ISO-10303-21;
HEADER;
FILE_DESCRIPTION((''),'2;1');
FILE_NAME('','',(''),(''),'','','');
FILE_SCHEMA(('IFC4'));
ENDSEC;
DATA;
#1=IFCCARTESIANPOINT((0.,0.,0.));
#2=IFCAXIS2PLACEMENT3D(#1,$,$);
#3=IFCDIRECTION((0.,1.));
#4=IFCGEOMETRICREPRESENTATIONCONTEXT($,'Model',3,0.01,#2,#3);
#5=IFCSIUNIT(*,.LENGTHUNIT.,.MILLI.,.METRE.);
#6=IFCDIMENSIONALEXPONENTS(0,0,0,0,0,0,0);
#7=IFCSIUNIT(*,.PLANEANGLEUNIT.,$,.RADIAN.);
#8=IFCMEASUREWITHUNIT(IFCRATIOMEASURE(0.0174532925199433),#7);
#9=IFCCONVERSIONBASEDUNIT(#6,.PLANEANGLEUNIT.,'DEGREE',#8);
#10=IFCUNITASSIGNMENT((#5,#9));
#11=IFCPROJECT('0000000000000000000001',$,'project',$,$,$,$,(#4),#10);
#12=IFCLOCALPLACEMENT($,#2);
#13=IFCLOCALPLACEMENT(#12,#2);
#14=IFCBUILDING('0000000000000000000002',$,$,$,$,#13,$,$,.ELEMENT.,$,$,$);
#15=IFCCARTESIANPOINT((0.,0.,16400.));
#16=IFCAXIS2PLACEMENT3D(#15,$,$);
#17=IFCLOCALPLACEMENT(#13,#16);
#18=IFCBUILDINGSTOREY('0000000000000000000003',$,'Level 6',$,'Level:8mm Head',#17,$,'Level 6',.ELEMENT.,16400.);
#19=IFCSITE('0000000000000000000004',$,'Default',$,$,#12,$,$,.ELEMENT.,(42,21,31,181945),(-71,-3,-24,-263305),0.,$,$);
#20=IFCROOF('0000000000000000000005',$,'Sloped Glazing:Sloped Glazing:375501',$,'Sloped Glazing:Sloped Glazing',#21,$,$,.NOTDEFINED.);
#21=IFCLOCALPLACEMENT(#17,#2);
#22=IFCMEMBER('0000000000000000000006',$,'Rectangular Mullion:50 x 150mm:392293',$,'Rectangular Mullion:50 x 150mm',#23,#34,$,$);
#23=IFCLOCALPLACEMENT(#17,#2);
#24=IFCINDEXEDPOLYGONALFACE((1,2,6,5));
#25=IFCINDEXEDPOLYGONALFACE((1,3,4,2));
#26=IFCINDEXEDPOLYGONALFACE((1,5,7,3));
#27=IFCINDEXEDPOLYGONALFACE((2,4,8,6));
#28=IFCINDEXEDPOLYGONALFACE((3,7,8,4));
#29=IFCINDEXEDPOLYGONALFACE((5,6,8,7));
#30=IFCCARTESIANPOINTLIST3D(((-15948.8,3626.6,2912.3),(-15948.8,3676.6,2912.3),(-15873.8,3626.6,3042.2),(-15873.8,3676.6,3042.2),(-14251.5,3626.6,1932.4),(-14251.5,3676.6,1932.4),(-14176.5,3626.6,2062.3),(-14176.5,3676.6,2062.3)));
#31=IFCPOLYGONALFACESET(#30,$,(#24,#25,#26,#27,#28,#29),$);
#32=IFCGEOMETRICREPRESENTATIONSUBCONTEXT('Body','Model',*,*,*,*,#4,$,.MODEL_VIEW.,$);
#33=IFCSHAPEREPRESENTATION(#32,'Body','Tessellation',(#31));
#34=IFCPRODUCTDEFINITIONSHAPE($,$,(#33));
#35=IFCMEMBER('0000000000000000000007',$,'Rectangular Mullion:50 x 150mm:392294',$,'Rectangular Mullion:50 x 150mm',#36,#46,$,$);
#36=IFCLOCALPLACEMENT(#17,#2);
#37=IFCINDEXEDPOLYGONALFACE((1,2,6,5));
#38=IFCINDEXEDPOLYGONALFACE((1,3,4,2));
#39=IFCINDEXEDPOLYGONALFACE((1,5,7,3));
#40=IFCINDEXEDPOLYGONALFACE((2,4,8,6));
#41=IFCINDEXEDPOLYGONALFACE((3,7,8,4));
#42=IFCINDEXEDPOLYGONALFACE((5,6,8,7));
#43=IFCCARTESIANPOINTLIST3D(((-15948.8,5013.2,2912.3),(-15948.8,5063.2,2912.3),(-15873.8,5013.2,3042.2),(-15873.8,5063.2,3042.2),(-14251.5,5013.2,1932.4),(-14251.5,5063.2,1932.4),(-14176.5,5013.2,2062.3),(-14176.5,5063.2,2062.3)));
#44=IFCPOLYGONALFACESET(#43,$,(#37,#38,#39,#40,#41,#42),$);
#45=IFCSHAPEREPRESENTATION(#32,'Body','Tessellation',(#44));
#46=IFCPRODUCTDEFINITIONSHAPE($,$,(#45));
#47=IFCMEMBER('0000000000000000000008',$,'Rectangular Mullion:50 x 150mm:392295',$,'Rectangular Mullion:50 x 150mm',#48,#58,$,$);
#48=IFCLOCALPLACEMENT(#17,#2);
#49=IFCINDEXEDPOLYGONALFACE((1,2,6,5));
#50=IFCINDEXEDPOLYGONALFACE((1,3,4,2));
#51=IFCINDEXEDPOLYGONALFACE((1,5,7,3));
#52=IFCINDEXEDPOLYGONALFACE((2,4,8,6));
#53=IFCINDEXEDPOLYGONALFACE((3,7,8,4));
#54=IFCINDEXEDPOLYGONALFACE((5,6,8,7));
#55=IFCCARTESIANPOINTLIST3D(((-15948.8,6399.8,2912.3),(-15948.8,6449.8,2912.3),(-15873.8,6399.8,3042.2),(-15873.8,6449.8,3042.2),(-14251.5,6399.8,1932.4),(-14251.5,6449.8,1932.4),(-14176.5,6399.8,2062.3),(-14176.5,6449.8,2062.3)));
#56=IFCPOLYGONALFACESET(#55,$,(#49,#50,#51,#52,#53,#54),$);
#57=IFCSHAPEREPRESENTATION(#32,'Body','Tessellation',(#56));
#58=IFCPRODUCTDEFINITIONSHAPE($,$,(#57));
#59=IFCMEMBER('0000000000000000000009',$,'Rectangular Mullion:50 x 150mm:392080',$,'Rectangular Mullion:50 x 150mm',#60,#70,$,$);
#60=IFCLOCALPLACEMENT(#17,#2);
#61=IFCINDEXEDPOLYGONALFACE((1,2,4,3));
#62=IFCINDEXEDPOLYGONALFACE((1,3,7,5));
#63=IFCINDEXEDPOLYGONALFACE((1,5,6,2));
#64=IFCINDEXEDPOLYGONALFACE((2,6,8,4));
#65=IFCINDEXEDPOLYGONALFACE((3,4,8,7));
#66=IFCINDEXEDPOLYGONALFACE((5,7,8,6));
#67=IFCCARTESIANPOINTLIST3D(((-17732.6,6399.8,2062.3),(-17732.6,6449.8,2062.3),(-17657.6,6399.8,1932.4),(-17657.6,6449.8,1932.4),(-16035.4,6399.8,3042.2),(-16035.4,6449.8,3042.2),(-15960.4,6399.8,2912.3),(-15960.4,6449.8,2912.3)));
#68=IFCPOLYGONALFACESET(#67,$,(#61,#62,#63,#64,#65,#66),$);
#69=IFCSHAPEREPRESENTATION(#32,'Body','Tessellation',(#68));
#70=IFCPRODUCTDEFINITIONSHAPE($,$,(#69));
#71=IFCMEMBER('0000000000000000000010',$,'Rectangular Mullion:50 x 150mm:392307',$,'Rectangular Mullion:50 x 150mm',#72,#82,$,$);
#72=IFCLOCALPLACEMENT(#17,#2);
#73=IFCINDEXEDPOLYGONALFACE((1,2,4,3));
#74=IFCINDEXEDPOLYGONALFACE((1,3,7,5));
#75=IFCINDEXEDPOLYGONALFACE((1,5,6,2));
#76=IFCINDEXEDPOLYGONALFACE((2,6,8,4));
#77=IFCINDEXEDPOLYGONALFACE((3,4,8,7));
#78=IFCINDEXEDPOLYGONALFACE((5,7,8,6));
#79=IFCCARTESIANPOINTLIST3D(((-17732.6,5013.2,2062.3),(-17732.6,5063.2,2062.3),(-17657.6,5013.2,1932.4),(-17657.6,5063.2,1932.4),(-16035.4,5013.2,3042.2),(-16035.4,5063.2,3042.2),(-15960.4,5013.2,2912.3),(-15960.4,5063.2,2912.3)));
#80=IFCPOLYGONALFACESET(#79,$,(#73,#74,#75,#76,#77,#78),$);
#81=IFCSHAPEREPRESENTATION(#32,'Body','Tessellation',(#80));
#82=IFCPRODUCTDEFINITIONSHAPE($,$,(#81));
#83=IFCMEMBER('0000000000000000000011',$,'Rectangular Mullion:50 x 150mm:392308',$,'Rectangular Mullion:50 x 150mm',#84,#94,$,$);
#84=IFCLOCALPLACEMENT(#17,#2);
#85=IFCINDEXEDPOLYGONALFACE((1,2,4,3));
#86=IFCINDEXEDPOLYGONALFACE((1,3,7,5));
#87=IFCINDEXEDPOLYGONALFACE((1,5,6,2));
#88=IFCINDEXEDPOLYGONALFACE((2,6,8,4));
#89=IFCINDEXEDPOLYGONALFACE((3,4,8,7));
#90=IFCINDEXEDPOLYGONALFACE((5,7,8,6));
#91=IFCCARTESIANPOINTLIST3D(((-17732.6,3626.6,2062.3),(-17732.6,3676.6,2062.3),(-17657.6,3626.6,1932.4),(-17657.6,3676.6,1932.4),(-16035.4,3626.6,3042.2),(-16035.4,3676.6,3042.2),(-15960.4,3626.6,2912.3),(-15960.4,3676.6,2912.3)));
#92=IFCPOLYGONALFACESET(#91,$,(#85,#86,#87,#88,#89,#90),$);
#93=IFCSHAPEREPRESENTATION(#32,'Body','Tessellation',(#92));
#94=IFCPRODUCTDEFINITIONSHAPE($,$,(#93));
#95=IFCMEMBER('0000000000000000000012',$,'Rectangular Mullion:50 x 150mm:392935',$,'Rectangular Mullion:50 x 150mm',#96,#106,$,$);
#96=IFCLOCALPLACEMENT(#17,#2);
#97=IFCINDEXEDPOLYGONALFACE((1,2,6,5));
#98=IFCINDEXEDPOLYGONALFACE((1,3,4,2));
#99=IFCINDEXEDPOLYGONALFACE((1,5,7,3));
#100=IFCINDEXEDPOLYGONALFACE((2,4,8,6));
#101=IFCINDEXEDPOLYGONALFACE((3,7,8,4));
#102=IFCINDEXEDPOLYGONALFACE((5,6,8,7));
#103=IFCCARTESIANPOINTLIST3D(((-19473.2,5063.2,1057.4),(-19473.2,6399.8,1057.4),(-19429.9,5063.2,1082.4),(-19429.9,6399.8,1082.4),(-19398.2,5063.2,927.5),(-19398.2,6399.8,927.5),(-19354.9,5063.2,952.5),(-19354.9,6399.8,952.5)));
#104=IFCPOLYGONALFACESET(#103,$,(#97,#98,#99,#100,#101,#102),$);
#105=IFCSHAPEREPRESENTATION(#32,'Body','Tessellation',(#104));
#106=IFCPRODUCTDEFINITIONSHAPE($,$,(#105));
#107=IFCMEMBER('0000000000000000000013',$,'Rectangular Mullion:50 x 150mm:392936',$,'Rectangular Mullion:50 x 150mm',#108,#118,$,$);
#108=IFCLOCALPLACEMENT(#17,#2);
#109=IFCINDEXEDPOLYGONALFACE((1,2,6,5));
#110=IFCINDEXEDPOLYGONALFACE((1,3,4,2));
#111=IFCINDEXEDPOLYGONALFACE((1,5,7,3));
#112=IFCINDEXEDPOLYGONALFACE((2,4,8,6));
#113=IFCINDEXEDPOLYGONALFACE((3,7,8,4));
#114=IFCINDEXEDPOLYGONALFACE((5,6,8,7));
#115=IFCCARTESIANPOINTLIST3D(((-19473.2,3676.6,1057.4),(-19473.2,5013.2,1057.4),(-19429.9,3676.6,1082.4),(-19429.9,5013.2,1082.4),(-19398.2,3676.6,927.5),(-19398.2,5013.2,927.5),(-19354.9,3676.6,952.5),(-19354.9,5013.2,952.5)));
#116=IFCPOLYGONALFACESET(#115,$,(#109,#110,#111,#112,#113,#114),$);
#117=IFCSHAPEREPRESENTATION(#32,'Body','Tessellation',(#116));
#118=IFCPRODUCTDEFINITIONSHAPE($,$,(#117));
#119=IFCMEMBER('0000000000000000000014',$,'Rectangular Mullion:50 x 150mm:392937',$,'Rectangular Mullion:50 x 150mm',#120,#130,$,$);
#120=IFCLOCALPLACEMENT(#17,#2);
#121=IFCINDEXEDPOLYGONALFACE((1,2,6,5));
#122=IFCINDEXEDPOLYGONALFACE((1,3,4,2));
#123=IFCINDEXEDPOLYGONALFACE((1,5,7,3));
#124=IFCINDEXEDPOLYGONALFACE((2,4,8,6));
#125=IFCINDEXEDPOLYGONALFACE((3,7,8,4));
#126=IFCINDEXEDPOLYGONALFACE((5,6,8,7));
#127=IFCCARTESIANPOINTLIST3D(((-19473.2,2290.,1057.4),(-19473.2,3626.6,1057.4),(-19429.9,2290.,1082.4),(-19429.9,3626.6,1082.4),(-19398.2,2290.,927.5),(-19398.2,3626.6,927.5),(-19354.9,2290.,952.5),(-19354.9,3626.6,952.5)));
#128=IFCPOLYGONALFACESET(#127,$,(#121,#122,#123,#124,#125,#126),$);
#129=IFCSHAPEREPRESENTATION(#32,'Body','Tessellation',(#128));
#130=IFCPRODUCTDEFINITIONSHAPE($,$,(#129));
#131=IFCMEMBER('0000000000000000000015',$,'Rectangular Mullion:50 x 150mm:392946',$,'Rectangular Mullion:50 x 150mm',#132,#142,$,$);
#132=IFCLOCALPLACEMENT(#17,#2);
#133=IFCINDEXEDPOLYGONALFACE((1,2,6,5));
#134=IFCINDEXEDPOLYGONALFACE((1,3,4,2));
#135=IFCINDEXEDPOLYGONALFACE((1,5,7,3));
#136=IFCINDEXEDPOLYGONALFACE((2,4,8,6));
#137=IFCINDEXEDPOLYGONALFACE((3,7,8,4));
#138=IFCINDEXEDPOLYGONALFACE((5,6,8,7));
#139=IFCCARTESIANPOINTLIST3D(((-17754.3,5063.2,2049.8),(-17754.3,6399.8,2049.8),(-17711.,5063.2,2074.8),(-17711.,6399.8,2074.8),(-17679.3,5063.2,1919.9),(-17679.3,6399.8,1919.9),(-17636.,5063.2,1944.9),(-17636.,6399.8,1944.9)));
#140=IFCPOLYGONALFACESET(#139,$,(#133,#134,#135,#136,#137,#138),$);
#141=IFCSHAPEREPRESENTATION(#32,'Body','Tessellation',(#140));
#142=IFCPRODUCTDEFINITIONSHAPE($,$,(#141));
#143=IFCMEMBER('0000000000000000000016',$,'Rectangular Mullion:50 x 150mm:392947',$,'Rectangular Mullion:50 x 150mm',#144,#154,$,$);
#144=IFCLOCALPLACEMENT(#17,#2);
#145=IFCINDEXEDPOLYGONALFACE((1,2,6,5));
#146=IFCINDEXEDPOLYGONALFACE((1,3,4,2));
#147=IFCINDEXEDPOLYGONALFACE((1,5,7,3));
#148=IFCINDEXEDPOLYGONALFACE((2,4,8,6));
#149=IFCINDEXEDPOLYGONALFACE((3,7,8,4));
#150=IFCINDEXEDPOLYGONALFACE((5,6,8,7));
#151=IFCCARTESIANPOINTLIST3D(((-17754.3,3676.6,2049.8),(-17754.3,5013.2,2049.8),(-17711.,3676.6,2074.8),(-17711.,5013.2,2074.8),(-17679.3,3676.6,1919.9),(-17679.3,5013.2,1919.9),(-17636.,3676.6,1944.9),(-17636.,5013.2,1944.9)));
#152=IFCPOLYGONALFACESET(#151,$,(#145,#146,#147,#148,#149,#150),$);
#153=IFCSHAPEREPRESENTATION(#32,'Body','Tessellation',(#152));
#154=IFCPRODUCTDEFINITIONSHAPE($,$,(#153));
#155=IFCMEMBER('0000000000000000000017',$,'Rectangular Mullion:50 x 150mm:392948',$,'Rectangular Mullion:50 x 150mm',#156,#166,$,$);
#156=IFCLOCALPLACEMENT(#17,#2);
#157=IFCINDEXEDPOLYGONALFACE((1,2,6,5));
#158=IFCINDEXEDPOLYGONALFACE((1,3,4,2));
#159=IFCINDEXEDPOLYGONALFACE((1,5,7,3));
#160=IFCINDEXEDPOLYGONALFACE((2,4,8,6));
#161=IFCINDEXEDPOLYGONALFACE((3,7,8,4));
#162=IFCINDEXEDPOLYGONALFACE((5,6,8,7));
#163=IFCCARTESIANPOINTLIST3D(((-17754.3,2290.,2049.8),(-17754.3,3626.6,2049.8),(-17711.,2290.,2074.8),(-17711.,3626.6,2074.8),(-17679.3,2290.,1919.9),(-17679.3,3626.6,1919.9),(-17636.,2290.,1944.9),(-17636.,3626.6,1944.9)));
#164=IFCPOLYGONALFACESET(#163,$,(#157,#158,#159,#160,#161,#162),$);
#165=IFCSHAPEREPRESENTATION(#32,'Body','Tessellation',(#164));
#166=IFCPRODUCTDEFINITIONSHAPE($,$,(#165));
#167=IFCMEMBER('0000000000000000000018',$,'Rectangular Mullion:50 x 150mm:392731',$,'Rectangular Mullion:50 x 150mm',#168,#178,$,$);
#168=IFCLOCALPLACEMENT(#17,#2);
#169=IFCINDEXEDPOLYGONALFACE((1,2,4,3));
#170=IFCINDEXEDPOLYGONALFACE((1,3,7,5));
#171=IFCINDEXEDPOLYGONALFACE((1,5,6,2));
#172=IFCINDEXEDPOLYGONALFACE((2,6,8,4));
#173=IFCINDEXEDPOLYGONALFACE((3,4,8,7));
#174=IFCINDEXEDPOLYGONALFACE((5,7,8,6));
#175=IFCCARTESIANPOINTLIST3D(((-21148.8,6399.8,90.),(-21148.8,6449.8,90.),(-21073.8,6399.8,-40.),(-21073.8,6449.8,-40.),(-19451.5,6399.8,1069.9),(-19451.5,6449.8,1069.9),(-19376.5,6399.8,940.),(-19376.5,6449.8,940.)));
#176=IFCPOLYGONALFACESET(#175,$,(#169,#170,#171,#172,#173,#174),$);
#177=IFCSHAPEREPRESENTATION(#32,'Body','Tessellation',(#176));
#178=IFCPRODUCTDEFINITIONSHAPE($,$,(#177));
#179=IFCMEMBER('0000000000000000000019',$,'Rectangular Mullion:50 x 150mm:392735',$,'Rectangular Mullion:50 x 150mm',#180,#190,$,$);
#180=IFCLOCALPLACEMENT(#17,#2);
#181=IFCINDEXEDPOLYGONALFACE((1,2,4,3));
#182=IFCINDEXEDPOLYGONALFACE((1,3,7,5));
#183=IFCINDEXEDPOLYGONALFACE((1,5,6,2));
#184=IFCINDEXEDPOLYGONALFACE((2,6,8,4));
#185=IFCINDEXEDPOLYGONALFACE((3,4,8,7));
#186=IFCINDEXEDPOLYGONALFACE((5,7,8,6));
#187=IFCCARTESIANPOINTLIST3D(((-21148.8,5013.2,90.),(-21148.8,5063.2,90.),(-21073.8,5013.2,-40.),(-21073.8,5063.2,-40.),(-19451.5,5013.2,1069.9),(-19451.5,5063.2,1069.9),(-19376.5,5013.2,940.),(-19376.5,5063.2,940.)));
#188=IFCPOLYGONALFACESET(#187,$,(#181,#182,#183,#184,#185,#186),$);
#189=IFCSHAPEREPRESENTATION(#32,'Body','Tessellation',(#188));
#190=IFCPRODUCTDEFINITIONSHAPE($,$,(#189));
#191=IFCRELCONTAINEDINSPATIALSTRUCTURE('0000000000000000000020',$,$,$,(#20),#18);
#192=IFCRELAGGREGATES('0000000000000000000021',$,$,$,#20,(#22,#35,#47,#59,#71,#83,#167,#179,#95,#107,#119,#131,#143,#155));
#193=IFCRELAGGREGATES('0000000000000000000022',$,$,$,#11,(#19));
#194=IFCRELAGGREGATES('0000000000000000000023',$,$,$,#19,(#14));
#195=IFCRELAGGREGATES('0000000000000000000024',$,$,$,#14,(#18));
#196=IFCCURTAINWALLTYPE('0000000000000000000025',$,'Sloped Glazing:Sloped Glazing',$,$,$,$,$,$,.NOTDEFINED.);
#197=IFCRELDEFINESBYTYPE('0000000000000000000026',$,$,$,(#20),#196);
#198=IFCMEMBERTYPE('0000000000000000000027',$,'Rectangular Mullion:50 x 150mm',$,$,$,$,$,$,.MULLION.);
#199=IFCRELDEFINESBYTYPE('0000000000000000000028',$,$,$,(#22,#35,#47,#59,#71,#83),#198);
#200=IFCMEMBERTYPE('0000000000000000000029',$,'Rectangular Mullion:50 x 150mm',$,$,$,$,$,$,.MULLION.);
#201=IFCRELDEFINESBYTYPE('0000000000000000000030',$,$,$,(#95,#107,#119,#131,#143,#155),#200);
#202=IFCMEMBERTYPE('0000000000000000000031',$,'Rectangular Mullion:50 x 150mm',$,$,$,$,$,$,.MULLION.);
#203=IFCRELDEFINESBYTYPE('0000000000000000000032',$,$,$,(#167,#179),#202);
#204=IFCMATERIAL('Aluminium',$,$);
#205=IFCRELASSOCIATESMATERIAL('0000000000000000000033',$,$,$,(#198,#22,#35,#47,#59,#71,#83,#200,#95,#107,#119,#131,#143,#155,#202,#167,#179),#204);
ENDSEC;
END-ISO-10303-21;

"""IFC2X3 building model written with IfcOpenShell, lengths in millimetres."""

from ifc_helpers import new_model, entity, si_unit, converted_unit, direction, frame, origin, origin_2d_with_axis, place, context, subcontext, project, spatial, rectangle, extrude, source, transform, mapped, material, type_object, type_shapes, element, aggregate, save


model = new_model("IFC2X3")

# Units and contexts
model_context = context("Model", 3, precision=0.01, world=origin(), true_north=direction((0.0, 1.0)))
body_context = subcontext(model_context, "Body", "Model", "MODEL_VIEW")
ifc_project = project(units=[si_unit("LENGTHUNIT", "METRE", prefix="MILLI"), converted_unit("PLANEANGLEUNIT", "DEGREE", entity("IfcRatioMeasure", 0.0174532925199433), si_unit("PLANEANGLEUNIT", "RADIAN"), dimensions=[0, 0, 0, 0, 0, 0, 0])], contexts=[model_context])

# Site, building, storey
site_placement = place(None, frame((0.0, 0.0, 0.0)))
site = spatial("IfcSite", under=ifc_project, at=site_placement, Name="Default", CompositionType="ELEMENT", RefLatitude=(42, 21, 31, 181945), RefLongitude=(-71, -3, -24, -263305), RefElevation=0.0)
building_placement = place(site_placement, origin())
building = spatial("IfcBuilding", under=site, at=building_placement, CompositionType="ELEMENT")
storey_placement = place(building_placement, frame((0.0, 0.0, 16400.0)))
storey = spatial("IfcBuildingStorey", under=building, at=storey_placement, Name="Level 6", ObjectType="Level:8mm Head", LongName="Level 6", CompositionType="ELEMENT", Elevation=16400.0)

# Roof, members
curtain_wall_type = type_object("IfcCurtainWallType", Name="Sloped Glazing:Sloped Glazing", PredefinedType="NOTDEFINED")
roof_placement = place(storey_placement, frame((0.0, 0.0, -16400.0)))
roof = element("IfcRoof", 1, at=roof_placement, inside=storey, type_object=curtain_wall_type, Name="Sloped Glazing:Sloped Glazing:375501", ObjectType="Sloped Glazing:Sloped Glazing", ShapeType="NOTDEFINED")
ifc_material_1 = material(Name="Aluminium")
member_type_1 = type_object("IfcMemberType", Name="Rectangular Mullion:50 x 150mm", PredefinedType="MULLION", material=ifc_material_1)
shared_shape_1 = source(origin(), body_context, "Body", "SweptSolid", [
    extrude(rectangle(XDim=150.0, YDim=50.0, at=origin_2d_with_axis()), frame((0.0, 0.0, -1959.8), z_axis=(0.0, 0.0, 1.0), x_axis=(0.0, -1.0, 0.0)), (0.0, 0.0, 1.0), 1959.8),
])
type_shapes(member_type_1, [shared_shape_1])
member_1_placement = place(storey_placement, frame((-15911.3, 3651.6, 2977.2), z_axis=(-0.866025, 0.0, 0.5), x_axis=(0.0, 1.0, 0.0)))
member_1 = element("IfcMember", 2, at=member_1_placement, type_object=member_type_1, material=ifc_material_1, Name="Rectangular Mullion:50 x 150mm:392293", ObjectType="Rectangular Mullion:50 x 150mm", context=body_context, shape_type="MappedRepresentation", body=[
    mapped(shared_shape_1, transform((0.0, 0.0, 0.0), scale=1.0)),
])
member_2_placement = place(storey_placement, frame((-15911.3, 5038.2, 2977.2), z_axis=(-0.866025, 0.0, 0.5), x_axis=(0.0, 1.0, 0.0)))
member_2 = element("IfcMember", 3, at=member_2_placement, type_object=member_type_1, material=ifc_material_1, Name="Rectangular Mullion:50 x 150mm:392294", ObjectType="Rectangular Mullion:50 x 150mm", context=body_context, shape_type="MappedRepresentation", body=[
    mapped(shared_shape_1, transform((0.0, 0.0, 0.0), scale=1.0)),
])
member_3_placement = place(storey_placement, frame((-15911.3, 6424.8, 2977.2), z_axis=(-0.866025, 0.0, 0.5), x_axis=(0.0, 1.0, 0.0)))
member_3 = element("IfcMember", 4, at=member_3_placement, type_object=member_type_1, material=ifc_material_1, Name="Rectangular Mullion:50 x 150mm:392295", ObjectType="Rectangular Mullion:50 x 150mm", context=body_context, shape_type="MappedRepresentation", body=[
    mapped(shared_shape_1, transform((0.0, 0.0, 0.0), scale=1.0)),
])
member_4_placement = place(storey_placement, frame((-15997.9, 6424.8, 2977.2), z_axis=(0.866025, 0.0, 0.5), x_axis=(0.0, -1.0, 0.0)))
member_4 = element("IfcMember", 5, at=member_4_placement, type_object=member_type_1, material=ifc_material_1, Name="Rectangular Mullion:50 x 150mm:392080", ObjectType="Rectangular Mullion:50 x 150mm", context=body_context, shape_type="MappedRepresentation", body=[
    mapped(shared_shape_1, transform((0.0, 0.0, 0.0), scale=1.0)),
])
member_5_placement = place(storey_placement, frame((-15997.9, 5038.2, 2977.2), z_axis=(0.866025, 0.0, 0.5), x_axis=(0.0, -1.0, 0.0)))
member_5 = element("IfcMember", 6, at=member_5_placement, type_object=member_type_1, material=ifc_material_1, Name="Rectangular Mullion:50 x 150mm:392307", ObjectType="Rectangular Mullion:50 x 150mm", context=body_context, shape_type="MappedRepresentation", body=[
    mapped(shared_shape_1, transform((0.0, 0.0, 0.0), scale=1.0)),
])
member_6_placement = place(storey_placement, frame((-15997.9, 3651.6, 2977.2), z_axis=(0.866025, 0.0, 0.5), x_axis=(0.0, -1.0, 0.0)))
member_6 = element("IfcMember", 7, at=member_6_placement, type_object=member_type_1, material=ifc_material_1, Name="Rectangular Mullion:50 x 150mm:392308", ObjectType="Rectangular Mullion:50 x 150mm", context=body_context, shape_type="MappedRepresentation", body=[
    mapped(shared_shape_1, transform((0.0, 0.0, 0.0), scale=1.0)),
])
member_type_2 = type_object("IfcMemberType", Name="Rectangular Mullion:50 x 150mm", PredefinedType="MULLION", material=ifc_material_1)
shared_shape_2 = source(origin(), body_context, "Body", "SweptSolid", [
    extrude(rectangle(XDim=150.0, YDim=50.0, at=origin_2d_with_axis()), frame((0.0, 0.0, -1336.6), z_axis=(0.0, 0.0, 1.0), x_axis=(0.0, -1.0, 0.0)), (0.0, 0.0, 1.0), 1336.6),
])
type_shapes(member_type_2, [shared_shape_2])
member_7_placement = place(storey_placement, frame((-19414.0, 6399.8, 1004.9), z_axis=(0.0, 1.0, 0.0), x_axis=(0.866025, 0.0, 0.5)))
member_7 = element("IfcMember", 8, at=member_7_placement, type_object=member_type_2, material=ifc_material_1, Name="Rectangular Mullion:50 x 150mm:392935", ObjectType="Rectangular Mullion:50 x 150mm", context=body_context, shape_type="MappedRepresentation", body=[
    mapped(shared_shape_2, transform((0.0, 0.0, 0.0), scale=1.0)),
])
member_8_placement = place(storey_placement, frame((-19414.0, 5013.2, 1004.9), z_axis=(0.0, 1.0, 0.0), x_axis=(0.866025, 0.0, 0.5)))
member_8 = element("IfcMember", 9, at=member_8_placement, type_object=member_type_2, material=ifc_material_1, Name="Rectangular Mullion:50 x 150mm:392936", ObjectType="Rectangular Mullion:50 x 150mm", context=body_context, shape_type="MappedRepresentation", body=[
    mapped(shared_shape_2, transform((0.0, 0.0, 0.0), scale=1.0)),
])
member_9_placement = place(storey_placement, frame((-19414.0, 3626.6, 1004.9), z_axis=(0.0, 1.0, 0.0), x_axis=(0.866025, 0.0, 0.5)))
member_9 = element("IfcMember", 10, at=member_9_placement, type_object=member_type_2, material=ifc_material_1, Name="Rectangular Mullion:50 x 150mm:392937", ObjectType="Rectangular Mullion:50 x 150mm", context=body_context, shape_type="MappedRepresentation", body=[
    mapped(shared_shape_2, transform((0.0, 0.0, 0.0), scale=1.0)),
])
member_10_placement = place(storey_placement, frame((-17695.1, 6399.8, 1997.3), z_axis=(0.0, 1.0, 0.0), x_axis=(0.866025, 0.0, 0.5)))
member_10 = element("IfcMember", 11, at=member_10_placement, type_object=member_type_2, material=ifc_material_1, Name="Rectangular Mullion:50 x 150mm:392946", ObjectType="Rectangular Mullion:50 x 150mm", context=body_context, shape_type="MappedRepresentation", body=[
    mapped(shared_shape_2, transform((0.0, 0.0, 0.0), scale=1.0)),
])
member_11_placement = place(storey_placement, frame((-17695.1, 5013.2, 1997.3), z_axis=(0.0, 1.0, 0.0), x_axis=(0.866025, 0.0, 0.5)))
member_11 = element("IfcMember", 12, at=member_11_placement, type_object=member_type_2, material=ifc_material_1, Name="Rectangular Mullion:50 x 150mm:392947", ObjectType="Rectangular Mullion:50 x 150mm", context=body_context, shape_type="MappedRepresentation", body=[
    mapped(shared_shape_2, transform((0.0, 0.0, 0.0), scale=1.0)),
])
member_12_placement = place(storey_placement, frame((-17695.1, 3626.6, 1997.3), z_axis=(0.0, 1.0, 0.0), x_axis=(0.866025, 0.0, 0.5)))
member_12 = element("IfcMember", 13, at=member_12_placement, type_object=member_type_2, material=ifc_material_1, Name="Rectangular Mullion:50 x 150mm:392948", ObjectType="Rectangular Mullion:50 x 150mm", context=body_context, shape_type="MappedRepresentation", body=[
    mapped(shared_shape_2, transform((0.0, 0.0, 0.0), scale=1.0)),
])
member_type_3 = type_object("IfcMemberType", Name="Rectangular Mullion:50 x 150mm", PredefinedType="MULLION", material=ifc_material_1)
shared_shape_3 = source(origin(), body_context, "Body", "SweptSolid", [
    extrude(rectangle(XDim=150.0, YDim=50.0, at=origin_2d_with_axis()), frame((0.0, 0.0, -1959.8), z_axis=(0.0, 0.0, 1.0), x_axis=(0.0, -1.0, 0.0)), (0.0, 0.0, 1.0), 1959.8),
])
type_shapes(member_type_3, [shared_shape_3])
member_13_placement = place(storey_placement, frame((-19414.0, 6424.8, 1004.9), z_axis=(0.866025, 0.0, 0.5), x_axis=(0.0, -1.0, 0.0)))
member_13 = element("IfcMember", 14, at=member_13_placement, type_object=member_type_3, material=ifc_material_1, Name="Rectangular Mullion:50 x 150mm:392731", ObjectType="Rectangular Mullion:50 x 150mm", context=body_context, shape_type="MappedRepresentation", body=[
    mapped(shared_shape_3, transform((0.0, 0.0, 0.0), scale=1.0)),
])
member_14_placement = place(storey_placement, frame((-19414.0, 5038.2, 1004.9), z_axis=(0.866025, 0.0, 0.5), x_axis=(0.0, -1.0, 0.0)))
member_14 = element("IfcMember", 15, at=member_14_placement, type_object=member_type_3, material=ifc_material_1, Name="Rectangular Mullion:50 x 150mm:392735", ObjectType="Rectangular Mullion:50 x 150mm", context=body_context, shape_type="MappedRepresentation", body=[
    mapped(shared_shape_3, transform((0.0, 0.0, 0.0), scale=1.0)),
])
aggregate(roof, [member_1, member_2, member_3, member_4, member_5, member_6, member_13, member_14, member_7, member_8, member_9, member_10, member_11, member_12])

save(model, "model.ifc")
